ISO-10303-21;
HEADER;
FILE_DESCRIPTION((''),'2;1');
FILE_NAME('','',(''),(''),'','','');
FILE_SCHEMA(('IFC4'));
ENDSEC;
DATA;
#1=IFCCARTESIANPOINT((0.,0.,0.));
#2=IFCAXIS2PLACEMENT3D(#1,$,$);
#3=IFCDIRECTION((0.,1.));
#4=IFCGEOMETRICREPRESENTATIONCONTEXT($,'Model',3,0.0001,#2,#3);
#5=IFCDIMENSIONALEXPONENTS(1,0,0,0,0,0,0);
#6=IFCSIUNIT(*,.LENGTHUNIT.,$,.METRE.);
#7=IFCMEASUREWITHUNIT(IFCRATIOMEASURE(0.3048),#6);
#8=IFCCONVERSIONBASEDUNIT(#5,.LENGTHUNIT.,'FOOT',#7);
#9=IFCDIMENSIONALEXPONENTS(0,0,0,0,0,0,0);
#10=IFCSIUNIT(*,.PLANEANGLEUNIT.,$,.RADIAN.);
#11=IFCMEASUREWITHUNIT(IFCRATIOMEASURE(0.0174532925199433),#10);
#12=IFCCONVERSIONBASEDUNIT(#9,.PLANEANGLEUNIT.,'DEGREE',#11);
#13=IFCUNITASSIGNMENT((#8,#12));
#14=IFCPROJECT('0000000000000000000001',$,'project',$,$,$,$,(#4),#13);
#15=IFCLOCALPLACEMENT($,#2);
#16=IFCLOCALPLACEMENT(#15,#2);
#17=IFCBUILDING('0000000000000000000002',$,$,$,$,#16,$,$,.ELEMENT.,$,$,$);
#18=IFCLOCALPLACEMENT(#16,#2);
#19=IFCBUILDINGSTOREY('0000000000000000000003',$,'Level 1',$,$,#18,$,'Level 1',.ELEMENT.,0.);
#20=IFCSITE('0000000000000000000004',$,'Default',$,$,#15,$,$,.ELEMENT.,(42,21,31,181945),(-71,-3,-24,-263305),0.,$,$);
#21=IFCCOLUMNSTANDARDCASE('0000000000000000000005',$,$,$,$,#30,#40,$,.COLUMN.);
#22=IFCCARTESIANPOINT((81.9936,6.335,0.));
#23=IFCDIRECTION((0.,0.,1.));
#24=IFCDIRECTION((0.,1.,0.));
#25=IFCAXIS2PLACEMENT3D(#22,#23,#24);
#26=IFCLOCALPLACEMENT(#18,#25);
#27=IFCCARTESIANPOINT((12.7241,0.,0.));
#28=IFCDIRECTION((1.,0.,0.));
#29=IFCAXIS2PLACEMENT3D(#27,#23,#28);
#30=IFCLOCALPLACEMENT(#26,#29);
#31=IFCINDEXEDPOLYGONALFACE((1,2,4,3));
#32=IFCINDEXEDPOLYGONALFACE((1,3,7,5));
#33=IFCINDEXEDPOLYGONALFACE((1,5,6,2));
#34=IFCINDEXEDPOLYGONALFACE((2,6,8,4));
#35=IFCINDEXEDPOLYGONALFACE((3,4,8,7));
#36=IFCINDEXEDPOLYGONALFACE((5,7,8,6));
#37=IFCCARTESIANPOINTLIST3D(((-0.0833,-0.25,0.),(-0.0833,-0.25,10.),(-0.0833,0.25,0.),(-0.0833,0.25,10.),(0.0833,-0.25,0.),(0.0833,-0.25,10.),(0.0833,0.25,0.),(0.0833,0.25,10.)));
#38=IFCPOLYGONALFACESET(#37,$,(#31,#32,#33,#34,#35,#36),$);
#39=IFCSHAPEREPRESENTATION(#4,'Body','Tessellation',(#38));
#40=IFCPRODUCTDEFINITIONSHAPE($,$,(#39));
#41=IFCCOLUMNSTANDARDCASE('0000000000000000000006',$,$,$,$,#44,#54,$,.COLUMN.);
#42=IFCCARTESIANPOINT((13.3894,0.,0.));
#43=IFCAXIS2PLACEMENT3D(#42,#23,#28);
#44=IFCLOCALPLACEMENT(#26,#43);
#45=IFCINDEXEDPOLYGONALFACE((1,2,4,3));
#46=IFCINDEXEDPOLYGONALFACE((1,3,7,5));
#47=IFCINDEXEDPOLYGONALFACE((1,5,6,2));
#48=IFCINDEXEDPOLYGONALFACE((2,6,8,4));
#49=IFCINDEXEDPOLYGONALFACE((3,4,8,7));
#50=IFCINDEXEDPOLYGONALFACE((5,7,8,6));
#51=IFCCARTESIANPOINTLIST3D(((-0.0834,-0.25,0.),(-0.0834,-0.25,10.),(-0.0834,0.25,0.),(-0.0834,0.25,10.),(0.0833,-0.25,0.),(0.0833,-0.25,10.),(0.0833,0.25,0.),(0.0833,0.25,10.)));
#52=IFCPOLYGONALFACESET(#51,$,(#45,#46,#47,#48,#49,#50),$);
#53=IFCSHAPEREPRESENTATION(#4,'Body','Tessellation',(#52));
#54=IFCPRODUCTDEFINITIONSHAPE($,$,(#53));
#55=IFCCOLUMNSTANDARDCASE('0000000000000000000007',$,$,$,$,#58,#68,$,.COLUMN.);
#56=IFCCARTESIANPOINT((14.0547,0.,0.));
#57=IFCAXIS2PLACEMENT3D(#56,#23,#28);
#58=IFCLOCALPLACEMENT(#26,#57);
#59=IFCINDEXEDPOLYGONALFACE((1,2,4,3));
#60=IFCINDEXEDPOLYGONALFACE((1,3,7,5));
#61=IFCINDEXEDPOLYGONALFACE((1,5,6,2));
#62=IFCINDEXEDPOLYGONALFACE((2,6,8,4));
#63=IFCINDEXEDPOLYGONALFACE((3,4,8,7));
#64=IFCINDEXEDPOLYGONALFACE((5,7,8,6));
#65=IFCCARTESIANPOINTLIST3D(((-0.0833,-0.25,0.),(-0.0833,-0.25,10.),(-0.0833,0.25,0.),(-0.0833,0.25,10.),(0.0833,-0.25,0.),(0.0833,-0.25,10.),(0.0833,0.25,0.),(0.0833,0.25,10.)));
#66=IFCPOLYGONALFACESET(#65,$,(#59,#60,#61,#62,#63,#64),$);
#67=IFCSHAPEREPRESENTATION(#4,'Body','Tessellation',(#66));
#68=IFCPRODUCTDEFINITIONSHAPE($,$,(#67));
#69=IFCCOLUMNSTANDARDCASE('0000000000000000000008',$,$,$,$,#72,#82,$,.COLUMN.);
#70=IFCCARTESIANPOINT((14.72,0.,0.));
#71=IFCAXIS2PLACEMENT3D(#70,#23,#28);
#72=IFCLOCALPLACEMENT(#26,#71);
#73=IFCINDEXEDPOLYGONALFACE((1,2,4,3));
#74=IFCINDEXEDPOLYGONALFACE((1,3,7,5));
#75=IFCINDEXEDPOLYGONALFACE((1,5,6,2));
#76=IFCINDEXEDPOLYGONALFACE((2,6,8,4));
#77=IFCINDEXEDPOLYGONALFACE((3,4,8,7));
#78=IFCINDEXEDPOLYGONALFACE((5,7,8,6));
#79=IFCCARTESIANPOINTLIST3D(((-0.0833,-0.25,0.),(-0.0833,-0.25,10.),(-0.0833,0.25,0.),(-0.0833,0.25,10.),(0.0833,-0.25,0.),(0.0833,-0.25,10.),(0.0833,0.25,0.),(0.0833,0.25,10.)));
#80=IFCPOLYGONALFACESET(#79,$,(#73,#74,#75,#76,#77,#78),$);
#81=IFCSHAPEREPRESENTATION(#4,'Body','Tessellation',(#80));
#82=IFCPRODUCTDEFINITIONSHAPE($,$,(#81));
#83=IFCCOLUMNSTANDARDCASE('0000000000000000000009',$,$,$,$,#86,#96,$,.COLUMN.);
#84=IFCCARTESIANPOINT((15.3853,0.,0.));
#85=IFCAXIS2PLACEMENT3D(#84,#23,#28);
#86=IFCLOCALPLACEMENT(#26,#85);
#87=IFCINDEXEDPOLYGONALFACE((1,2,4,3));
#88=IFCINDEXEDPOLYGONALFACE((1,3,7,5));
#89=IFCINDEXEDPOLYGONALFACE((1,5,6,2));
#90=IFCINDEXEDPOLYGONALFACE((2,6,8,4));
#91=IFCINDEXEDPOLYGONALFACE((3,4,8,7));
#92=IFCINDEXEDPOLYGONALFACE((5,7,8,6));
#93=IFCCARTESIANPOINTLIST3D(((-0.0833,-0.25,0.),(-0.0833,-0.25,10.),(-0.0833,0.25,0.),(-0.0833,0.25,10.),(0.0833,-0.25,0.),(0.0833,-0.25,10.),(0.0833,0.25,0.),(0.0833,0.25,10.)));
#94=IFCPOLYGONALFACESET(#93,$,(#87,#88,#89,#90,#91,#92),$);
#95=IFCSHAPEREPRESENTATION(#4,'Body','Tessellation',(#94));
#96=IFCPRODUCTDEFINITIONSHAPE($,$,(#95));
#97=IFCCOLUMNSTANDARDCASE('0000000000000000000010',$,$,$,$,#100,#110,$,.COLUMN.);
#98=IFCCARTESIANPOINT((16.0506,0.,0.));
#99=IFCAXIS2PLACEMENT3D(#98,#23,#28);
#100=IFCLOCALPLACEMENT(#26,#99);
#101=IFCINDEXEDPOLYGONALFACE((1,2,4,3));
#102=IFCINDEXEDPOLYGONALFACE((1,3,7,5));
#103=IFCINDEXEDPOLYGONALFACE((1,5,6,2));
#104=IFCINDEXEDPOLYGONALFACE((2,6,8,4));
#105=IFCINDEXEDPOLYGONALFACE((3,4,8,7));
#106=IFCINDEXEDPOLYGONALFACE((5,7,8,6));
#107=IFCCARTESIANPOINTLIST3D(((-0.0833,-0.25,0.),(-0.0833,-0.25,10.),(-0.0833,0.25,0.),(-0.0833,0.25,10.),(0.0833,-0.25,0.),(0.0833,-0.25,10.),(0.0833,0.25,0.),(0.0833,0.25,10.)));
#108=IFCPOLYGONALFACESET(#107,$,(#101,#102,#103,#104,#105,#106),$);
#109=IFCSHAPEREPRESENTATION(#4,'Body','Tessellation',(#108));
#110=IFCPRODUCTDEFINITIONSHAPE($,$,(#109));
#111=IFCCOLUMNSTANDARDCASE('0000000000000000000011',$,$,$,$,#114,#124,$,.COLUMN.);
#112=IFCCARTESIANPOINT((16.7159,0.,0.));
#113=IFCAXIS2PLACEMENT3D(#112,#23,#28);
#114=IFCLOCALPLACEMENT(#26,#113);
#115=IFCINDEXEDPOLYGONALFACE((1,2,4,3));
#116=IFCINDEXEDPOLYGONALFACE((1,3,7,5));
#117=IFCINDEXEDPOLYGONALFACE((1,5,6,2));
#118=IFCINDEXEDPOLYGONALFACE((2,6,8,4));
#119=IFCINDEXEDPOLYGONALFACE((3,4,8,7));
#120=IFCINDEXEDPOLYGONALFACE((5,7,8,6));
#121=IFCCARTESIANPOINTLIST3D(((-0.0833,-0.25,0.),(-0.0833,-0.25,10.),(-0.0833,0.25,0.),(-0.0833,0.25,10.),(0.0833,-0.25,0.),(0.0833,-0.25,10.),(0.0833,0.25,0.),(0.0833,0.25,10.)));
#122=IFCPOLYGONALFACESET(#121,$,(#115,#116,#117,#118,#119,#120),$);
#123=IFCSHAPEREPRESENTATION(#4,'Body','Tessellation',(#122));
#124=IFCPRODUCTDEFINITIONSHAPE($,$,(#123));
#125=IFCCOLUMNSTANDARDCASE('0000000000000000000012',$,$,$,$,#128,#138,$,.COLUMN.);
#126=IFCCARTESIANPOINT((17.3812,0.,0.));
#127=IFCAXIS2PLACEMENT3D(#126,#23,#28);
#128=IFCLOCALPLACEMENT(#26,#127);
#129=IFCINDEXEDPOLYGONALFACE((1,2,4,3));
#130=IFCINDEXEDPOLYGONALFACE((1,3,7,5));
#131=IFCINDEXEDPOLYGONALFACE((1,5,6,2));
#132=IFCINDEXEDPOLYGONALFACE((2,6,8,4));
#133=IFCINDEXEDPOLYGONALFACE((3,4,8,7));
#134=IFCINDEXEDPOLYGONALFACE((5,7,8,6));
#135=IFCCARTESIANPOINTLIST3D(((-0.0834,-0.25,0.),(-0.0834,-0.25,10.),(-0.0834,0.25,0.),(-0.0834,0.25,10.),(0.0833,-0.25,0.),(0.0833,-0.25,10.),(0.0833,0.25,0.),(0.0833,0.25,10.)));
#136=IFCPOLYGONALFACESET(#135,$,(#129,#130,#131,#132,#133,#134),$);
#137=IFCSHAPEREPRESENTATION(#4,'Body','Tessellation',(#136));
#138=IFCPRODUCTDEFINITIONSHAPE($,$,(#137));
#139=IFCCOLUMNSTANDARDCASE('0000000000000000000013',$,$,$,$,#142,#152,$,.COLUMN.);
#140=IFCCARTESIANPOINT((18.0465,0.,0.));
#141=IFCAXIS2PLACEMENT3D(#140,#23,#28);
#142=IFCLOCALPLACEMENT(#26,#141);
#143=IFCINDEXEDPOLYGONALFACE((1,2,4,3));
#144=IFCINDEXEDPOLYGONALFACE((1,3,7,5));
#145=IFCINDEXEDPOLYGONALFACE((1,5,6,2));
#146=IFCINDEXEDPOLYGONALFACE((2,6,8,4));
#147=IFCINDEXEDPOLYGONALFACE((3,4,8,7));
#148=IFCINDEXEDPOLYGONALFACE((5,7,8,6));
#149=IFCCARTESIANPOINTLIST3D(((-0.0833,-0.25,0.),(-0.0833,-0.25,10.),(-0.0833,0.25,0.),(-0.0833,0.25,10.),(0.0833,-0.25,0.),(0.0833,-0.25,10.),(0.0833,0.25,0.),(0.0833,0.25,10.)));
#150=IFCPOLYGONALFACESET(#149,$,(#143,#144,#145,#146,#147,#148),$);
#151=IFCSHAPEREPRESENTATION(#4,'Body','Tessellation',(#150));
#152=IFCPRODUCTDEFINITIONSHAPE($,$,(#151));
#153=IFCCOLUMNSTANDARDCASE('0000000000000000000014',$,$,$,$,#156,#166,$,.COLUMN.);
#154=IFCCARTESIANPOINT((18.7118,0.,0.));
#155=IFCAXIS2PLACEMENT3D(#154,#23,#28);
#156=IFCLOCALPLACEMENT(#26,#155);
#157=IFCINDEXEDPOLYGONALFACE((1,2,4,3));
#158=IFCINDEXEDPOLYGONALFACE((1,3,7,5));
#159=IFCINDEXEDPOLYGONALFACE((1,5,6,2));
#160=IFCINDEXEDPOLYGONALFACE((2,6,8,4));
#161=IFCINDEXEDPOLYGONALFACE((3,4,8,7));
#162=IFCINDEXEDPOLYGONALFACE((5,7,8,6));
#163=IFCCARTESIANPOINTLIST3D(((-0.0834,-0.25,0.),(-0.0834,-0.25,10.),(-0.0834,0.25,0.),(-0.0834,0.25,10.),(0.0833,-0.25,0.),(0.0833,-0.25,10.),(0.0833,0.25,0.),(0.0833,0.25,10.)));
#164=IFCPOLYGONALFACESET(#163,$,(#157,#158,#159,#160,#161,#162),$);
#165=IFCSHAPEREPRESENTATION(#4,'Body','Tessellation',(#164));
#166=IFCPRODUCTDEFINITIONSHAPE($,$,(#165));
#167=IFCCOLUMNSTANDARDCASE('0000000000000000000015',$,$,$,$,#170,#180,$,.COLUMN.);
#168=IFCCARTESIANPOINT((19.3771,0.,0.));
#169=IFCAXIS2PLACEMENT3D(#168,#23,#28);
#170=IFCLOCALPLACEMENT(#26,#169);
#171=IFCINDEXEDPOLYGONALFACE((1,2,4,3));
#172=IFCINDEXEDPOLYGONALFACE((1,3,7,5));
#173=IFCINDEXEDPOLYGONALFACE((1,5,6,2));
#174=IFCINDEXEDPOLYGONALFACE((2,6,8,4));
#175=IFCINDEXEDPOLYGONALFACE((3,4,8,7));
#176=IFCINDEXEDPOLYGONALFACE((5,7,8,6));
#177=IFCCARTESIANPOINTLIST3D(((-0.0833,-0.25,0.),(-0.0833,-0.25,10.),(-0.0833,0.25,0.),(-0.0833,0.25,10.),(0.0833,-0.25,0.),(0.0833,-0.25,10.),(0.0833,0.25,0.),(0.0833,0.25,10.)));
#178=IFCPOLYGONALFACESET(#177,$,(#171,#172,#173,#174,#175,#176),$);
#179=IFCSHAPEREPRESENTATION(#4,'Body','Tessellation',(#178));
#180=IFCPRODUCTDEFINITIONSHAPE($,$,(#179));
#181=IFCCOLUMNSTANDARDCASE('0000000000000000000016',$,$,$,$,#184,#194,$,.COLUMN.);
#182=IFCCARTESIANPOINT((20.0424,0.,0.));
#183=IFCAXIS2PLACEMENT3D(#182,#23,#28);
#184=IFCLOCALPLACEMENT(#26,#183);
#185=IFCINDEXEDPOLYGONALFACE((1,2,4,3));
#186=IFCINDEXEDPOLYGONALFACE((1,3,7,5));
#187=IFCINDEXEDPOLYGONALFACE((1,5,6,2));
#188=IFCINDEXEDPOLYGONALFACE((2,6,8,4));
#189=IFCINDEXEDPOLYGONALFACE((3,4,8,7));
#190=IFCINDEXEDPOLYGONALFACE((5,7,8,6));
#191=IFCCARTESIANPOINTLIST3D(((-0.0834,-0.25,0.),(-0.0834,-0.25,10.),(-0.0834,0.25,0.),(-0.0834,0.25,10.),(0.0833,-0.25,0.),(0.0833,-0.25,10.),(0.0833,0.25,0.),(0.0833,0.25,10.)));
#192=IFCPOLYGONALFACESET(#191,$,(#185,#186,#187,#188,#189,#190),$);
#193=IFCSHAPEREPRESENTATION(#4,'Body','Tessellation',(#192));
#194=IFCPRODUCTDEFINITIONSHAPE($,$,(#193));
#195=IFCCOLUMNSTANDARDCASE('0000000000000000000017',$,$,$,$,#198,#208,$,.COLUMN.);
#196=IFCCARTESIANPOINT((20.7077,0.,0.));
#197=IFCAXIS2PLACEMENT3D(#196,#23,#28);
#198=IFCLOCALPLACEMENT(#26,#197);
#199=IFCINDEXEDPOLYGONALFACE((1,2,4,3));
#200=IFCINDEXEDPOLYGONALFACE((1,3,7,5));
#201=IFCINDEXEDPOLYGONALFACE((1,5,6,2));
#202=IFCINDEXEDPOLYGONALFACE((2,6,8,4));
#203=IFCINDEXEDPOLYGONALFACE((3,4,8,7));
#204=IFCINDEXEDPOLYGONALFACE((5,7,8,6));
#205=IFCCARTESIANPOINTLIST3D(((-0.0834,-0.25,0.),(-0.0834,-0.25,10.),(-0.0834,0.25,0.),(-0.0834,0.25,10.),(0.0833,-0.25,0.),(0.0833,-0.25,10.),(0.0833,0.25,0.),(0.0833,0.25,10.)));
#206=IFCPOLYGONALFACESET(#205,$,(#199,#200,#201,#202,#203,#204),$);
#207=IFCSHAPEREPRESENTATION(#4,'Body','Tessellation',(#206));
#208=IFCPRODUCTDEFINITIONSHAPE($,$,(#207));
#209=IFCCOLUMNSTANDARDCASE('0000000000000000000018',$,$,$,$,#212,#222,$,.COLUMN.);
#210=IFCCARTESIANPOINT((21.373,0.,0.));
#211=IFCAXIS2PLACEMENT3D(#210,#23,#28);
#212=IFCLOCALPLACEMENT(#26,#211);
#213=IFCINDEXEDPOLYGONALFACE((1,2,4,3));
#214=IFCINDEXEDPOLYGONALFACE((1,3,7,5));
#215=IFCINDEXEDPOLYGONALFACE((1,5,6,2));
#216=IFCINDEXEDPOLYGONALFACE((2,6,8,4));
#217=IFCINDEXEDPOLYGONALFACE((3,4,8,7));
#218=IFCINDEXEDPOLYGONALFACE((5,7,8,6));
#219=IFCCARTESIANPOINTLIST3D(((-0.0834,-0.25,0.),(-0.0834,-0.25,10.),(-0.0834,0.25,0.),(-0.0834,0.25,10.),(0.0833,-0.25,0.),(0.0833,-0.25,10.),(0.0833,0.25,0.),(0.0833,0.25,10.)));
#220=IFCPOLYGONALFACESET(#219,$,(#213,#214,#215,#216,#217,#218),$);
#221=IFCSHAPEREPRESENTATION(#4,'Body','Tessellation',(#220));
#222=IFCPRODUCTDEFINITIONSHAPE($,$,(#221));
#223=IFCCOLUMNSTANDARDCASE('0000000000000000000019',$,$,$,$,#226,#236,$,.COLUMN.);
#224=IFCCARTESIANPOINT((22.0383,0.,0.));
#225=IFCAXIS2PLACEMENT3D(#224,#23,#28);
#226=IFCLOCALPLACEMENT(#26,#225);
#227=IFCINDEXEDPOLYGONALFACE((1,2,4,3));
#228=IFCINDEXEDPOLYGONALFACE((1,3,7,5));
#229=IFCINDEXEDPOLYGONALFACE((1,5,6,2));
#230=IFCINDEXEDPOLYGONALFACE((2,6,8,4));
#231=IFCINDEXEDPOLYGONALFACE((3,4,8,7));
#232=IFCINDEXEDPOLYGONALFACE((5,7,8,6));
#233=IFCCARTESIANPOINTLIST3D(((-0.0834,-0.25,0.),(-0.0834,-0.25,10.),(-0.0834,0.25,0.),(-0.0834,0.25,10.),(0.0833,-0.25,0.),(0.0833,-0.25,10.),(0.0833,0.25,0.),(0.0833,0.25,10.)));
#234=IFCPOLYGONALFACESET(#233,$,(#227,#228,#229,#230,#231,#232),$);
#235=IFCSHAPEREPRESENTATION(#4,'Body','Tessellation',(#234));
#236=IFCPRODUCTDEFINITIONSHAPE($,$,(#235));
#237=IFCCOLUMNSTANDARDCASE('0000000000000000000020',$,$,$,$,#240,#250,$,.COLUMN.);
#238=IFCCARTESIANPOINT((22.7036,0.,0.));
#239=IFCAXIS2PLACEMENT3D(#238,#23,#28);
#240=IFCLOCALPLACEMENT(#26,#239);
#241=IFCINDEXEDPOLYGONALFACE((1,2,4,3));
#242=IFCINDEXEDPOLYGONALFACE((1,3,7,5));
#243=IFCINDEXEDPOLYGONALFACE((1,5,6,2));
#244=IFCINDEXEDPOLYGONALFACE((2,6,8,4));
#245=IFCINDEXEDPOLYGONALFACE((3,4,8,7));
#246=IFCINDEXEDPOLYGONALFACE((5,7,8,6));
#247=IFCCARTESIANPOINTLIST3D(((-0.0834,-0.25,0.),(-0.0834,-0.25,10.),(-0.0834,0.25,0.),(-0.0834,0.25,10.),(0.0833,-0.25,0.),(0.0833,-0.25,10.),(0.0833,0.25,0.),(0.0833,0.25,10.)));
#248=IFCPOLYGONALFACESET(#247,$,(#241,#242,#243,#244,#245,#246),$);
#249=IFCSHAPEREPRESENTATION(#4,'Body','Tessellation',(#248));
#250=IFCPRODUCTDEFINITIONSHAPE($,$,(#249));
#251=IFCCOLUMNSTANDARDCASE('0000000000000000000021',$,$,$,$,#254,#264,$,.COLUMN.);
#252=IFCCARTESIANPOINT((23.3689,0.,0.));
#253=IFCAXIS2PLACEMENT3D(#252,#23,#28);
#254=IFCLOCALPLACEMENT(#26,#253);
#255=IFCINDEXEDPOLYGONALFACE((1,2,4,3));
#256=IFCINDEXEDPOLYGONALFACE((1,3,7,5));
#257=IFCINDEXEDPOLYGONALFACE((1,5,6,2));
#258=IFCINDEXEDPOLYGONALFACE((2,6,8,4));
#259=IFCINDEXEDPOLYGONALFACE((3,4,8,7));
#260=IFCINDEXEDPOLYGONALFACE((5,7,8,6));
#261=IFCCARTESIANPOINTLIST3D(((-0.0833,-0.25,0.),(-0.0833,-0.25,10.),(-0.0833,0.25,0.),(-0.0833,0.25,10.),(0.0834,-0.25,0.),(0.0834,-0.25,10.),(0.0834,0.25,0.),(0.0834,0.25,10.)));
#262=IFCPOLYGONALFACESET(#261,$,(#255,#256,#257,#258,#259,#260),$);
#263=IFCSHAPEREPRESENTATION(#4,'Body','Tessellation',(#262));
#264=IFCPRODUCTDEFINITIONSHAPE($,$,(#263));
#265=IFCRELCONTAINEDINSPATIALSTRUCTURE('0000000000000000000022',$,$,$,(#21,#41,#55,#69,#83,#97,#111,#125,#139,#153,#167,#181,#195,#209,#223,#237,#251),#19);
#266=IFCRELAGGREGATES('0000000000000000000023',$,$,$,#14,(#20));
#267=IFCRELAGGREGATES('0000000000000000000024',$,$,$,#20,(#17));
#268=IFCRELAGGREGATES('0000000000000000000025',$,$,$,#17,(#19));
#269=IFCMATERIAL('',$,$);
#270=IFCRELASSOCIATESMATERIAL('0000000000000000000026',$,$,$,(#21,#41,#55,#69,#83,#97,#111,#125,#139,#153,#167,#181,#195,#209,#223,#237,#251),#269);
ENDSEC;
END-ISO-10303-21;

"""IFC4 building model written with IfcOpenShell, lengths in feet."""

from ifc_helpers import new_model, entity, si_unit, converted_unit, direction, frame, origin, place, context, project, spatial, rectangle, extrude, material, element, save


model = new_model("IFC4")

# Units and contexts
model_context = context("Model", 3, precision=0.0001, world=origin(), true_north=direction((0.0, 1.0)))
ifc_project = project(units=[converted_unit("LENGTHUNIT", "FOOT", entity("IfcRatioMeasure", 0.3048), si_unit("LENGTHUNIT", "METRE"), dimensions=[1, 0, 0, 0, 0, 0, 0]), converted_unit("PLANEANGLEUNIT", "DEGREE", entity("IfcRatioMeasure", 0.0174532925199433), si_unit("PLANEANGLEUNIT", "RADIAN"), dimensions=[0, 0, 0, 0, 0, 0, 0])], contexts=[model_context])

# Site, building, storey
site_placement = place(None, origin())
site = spatial("IfcSite", under=ifc_project, at=site_placement, Name="Default", CompositionType="ELEMENT", RefLatitude=(42, 21, 31, 181945), RefLongitude=(-71, -3, -24, -263305), RefElevation=0.0)
building_placement = place(site_placement, origin())
building = spatial("IfcBuilding", under=site, at=building_placement, CompositionType="ELEMENT")
storey_placement = place(building_placement, origin())
storey = spatial("IfcBuildingStorey", under=building, at=storey_placement, Name="Level 1", LongName="Level 1", CompositionType="ELEMENT", Elevation=0.0)

# Columns
ifc_material_1 = material(Name="")
placement_1 = place(storey_placement, frame((81.9936, 6.335, 0.0), z_axis=(0.0, 0.0, 1.0), x_axis=(0.0, 1.0, 0.0)))
for number, where, z_axis, x_axis in (
    (1, (12.7241, 0.0, 0.0), (0.0, 0.0, 1.0), (1.0, 0.0, 0.0)),
    (2, (13.3894, 0.0, 0.0), (0.0, 0.0, 1.0), (1.0, 0.0, 0.0)),
    (3, (14.0547, 0.0, 0.0), (0.0, 0.0, 1.0), (1.0, 0.0, 0.0)),
    (4, (14.72, 0.0, 0.0), (0.0, 0.0, 1.0), (1.0, 0.0, 0.0)),
    (5, (15.3853, 0.0, 0.0), (0.0, 0.0, 1.0), (1.0, 0.0, 0.0)),
    (6, (16.0506, 0.0, 0.0), (0.0, 0.0, 1.0), (1.0, 0.0, 0.0)),
    (7, (16.7159, 0.0, 0.0), (0.0, 0.0, 1.0), (1.0, 0.0, 0.0)),
    (8, (17.3812, 0.0, 0.0), (0.0, 0.0, 1.0), (1.0, 0.0, 0.0)),
    (9, (18.0465, 0.0, 0.0), (0.0, 0.0, 1.0), (1.0, 0.0, 0.0)),
    (10, (18.7118, 0.0, 0.0), (0.0, 0.0, 1.0), (1.0, 0.0, 0.0)),
    (11, (19.3771, 0.0, 0.0), (0.0, 0.0, 1.0), (1.0, 0.0, 0.0)),
    (12, (20.0424, 0.0, 0.0), (0.0, 0.0, 1.0), (1.0, 0.0, 0.0)),
    (13, (20.7077, 0.0, 0.0), (0.0, 0.0, 1.0), (1.0, 0.0, 0.0)),
    (14, (21.373, 0.0, 0.0), (0.0, 0.0, 1.0), (1.0, 0.0, 0.0)),
    (15, (22.0383, 0.0, 0.0), (0.0, 0.0, 1.0), (1.0, 0.0, 0.0)),
    (16, (22.7036, 0.0, 0.0), (0.0, 0.0, 1.0), (1.0, 0.0, 0.0)),
    (17, (23.3689, 0.0, 0.0), (0.0, 0.0, 1.0), (1.0, 0.0, 0.0)),
):
    element("IfcColumnStandardCase", number, at=place(placement_1, frame(where, z_axis=z_axis, x_axis=x_axis)), inside=storey, material=ifc_material_1, PredefinedType="COLUMN", context=model_context, shape_type="SweptSolid", body=[
        extrude(rectangle(XDim=0.1667, YDim=0.5), origin(), (0.0, 0.0, 1.0), 10.0),
    ])

save(model, "model.ifc")
